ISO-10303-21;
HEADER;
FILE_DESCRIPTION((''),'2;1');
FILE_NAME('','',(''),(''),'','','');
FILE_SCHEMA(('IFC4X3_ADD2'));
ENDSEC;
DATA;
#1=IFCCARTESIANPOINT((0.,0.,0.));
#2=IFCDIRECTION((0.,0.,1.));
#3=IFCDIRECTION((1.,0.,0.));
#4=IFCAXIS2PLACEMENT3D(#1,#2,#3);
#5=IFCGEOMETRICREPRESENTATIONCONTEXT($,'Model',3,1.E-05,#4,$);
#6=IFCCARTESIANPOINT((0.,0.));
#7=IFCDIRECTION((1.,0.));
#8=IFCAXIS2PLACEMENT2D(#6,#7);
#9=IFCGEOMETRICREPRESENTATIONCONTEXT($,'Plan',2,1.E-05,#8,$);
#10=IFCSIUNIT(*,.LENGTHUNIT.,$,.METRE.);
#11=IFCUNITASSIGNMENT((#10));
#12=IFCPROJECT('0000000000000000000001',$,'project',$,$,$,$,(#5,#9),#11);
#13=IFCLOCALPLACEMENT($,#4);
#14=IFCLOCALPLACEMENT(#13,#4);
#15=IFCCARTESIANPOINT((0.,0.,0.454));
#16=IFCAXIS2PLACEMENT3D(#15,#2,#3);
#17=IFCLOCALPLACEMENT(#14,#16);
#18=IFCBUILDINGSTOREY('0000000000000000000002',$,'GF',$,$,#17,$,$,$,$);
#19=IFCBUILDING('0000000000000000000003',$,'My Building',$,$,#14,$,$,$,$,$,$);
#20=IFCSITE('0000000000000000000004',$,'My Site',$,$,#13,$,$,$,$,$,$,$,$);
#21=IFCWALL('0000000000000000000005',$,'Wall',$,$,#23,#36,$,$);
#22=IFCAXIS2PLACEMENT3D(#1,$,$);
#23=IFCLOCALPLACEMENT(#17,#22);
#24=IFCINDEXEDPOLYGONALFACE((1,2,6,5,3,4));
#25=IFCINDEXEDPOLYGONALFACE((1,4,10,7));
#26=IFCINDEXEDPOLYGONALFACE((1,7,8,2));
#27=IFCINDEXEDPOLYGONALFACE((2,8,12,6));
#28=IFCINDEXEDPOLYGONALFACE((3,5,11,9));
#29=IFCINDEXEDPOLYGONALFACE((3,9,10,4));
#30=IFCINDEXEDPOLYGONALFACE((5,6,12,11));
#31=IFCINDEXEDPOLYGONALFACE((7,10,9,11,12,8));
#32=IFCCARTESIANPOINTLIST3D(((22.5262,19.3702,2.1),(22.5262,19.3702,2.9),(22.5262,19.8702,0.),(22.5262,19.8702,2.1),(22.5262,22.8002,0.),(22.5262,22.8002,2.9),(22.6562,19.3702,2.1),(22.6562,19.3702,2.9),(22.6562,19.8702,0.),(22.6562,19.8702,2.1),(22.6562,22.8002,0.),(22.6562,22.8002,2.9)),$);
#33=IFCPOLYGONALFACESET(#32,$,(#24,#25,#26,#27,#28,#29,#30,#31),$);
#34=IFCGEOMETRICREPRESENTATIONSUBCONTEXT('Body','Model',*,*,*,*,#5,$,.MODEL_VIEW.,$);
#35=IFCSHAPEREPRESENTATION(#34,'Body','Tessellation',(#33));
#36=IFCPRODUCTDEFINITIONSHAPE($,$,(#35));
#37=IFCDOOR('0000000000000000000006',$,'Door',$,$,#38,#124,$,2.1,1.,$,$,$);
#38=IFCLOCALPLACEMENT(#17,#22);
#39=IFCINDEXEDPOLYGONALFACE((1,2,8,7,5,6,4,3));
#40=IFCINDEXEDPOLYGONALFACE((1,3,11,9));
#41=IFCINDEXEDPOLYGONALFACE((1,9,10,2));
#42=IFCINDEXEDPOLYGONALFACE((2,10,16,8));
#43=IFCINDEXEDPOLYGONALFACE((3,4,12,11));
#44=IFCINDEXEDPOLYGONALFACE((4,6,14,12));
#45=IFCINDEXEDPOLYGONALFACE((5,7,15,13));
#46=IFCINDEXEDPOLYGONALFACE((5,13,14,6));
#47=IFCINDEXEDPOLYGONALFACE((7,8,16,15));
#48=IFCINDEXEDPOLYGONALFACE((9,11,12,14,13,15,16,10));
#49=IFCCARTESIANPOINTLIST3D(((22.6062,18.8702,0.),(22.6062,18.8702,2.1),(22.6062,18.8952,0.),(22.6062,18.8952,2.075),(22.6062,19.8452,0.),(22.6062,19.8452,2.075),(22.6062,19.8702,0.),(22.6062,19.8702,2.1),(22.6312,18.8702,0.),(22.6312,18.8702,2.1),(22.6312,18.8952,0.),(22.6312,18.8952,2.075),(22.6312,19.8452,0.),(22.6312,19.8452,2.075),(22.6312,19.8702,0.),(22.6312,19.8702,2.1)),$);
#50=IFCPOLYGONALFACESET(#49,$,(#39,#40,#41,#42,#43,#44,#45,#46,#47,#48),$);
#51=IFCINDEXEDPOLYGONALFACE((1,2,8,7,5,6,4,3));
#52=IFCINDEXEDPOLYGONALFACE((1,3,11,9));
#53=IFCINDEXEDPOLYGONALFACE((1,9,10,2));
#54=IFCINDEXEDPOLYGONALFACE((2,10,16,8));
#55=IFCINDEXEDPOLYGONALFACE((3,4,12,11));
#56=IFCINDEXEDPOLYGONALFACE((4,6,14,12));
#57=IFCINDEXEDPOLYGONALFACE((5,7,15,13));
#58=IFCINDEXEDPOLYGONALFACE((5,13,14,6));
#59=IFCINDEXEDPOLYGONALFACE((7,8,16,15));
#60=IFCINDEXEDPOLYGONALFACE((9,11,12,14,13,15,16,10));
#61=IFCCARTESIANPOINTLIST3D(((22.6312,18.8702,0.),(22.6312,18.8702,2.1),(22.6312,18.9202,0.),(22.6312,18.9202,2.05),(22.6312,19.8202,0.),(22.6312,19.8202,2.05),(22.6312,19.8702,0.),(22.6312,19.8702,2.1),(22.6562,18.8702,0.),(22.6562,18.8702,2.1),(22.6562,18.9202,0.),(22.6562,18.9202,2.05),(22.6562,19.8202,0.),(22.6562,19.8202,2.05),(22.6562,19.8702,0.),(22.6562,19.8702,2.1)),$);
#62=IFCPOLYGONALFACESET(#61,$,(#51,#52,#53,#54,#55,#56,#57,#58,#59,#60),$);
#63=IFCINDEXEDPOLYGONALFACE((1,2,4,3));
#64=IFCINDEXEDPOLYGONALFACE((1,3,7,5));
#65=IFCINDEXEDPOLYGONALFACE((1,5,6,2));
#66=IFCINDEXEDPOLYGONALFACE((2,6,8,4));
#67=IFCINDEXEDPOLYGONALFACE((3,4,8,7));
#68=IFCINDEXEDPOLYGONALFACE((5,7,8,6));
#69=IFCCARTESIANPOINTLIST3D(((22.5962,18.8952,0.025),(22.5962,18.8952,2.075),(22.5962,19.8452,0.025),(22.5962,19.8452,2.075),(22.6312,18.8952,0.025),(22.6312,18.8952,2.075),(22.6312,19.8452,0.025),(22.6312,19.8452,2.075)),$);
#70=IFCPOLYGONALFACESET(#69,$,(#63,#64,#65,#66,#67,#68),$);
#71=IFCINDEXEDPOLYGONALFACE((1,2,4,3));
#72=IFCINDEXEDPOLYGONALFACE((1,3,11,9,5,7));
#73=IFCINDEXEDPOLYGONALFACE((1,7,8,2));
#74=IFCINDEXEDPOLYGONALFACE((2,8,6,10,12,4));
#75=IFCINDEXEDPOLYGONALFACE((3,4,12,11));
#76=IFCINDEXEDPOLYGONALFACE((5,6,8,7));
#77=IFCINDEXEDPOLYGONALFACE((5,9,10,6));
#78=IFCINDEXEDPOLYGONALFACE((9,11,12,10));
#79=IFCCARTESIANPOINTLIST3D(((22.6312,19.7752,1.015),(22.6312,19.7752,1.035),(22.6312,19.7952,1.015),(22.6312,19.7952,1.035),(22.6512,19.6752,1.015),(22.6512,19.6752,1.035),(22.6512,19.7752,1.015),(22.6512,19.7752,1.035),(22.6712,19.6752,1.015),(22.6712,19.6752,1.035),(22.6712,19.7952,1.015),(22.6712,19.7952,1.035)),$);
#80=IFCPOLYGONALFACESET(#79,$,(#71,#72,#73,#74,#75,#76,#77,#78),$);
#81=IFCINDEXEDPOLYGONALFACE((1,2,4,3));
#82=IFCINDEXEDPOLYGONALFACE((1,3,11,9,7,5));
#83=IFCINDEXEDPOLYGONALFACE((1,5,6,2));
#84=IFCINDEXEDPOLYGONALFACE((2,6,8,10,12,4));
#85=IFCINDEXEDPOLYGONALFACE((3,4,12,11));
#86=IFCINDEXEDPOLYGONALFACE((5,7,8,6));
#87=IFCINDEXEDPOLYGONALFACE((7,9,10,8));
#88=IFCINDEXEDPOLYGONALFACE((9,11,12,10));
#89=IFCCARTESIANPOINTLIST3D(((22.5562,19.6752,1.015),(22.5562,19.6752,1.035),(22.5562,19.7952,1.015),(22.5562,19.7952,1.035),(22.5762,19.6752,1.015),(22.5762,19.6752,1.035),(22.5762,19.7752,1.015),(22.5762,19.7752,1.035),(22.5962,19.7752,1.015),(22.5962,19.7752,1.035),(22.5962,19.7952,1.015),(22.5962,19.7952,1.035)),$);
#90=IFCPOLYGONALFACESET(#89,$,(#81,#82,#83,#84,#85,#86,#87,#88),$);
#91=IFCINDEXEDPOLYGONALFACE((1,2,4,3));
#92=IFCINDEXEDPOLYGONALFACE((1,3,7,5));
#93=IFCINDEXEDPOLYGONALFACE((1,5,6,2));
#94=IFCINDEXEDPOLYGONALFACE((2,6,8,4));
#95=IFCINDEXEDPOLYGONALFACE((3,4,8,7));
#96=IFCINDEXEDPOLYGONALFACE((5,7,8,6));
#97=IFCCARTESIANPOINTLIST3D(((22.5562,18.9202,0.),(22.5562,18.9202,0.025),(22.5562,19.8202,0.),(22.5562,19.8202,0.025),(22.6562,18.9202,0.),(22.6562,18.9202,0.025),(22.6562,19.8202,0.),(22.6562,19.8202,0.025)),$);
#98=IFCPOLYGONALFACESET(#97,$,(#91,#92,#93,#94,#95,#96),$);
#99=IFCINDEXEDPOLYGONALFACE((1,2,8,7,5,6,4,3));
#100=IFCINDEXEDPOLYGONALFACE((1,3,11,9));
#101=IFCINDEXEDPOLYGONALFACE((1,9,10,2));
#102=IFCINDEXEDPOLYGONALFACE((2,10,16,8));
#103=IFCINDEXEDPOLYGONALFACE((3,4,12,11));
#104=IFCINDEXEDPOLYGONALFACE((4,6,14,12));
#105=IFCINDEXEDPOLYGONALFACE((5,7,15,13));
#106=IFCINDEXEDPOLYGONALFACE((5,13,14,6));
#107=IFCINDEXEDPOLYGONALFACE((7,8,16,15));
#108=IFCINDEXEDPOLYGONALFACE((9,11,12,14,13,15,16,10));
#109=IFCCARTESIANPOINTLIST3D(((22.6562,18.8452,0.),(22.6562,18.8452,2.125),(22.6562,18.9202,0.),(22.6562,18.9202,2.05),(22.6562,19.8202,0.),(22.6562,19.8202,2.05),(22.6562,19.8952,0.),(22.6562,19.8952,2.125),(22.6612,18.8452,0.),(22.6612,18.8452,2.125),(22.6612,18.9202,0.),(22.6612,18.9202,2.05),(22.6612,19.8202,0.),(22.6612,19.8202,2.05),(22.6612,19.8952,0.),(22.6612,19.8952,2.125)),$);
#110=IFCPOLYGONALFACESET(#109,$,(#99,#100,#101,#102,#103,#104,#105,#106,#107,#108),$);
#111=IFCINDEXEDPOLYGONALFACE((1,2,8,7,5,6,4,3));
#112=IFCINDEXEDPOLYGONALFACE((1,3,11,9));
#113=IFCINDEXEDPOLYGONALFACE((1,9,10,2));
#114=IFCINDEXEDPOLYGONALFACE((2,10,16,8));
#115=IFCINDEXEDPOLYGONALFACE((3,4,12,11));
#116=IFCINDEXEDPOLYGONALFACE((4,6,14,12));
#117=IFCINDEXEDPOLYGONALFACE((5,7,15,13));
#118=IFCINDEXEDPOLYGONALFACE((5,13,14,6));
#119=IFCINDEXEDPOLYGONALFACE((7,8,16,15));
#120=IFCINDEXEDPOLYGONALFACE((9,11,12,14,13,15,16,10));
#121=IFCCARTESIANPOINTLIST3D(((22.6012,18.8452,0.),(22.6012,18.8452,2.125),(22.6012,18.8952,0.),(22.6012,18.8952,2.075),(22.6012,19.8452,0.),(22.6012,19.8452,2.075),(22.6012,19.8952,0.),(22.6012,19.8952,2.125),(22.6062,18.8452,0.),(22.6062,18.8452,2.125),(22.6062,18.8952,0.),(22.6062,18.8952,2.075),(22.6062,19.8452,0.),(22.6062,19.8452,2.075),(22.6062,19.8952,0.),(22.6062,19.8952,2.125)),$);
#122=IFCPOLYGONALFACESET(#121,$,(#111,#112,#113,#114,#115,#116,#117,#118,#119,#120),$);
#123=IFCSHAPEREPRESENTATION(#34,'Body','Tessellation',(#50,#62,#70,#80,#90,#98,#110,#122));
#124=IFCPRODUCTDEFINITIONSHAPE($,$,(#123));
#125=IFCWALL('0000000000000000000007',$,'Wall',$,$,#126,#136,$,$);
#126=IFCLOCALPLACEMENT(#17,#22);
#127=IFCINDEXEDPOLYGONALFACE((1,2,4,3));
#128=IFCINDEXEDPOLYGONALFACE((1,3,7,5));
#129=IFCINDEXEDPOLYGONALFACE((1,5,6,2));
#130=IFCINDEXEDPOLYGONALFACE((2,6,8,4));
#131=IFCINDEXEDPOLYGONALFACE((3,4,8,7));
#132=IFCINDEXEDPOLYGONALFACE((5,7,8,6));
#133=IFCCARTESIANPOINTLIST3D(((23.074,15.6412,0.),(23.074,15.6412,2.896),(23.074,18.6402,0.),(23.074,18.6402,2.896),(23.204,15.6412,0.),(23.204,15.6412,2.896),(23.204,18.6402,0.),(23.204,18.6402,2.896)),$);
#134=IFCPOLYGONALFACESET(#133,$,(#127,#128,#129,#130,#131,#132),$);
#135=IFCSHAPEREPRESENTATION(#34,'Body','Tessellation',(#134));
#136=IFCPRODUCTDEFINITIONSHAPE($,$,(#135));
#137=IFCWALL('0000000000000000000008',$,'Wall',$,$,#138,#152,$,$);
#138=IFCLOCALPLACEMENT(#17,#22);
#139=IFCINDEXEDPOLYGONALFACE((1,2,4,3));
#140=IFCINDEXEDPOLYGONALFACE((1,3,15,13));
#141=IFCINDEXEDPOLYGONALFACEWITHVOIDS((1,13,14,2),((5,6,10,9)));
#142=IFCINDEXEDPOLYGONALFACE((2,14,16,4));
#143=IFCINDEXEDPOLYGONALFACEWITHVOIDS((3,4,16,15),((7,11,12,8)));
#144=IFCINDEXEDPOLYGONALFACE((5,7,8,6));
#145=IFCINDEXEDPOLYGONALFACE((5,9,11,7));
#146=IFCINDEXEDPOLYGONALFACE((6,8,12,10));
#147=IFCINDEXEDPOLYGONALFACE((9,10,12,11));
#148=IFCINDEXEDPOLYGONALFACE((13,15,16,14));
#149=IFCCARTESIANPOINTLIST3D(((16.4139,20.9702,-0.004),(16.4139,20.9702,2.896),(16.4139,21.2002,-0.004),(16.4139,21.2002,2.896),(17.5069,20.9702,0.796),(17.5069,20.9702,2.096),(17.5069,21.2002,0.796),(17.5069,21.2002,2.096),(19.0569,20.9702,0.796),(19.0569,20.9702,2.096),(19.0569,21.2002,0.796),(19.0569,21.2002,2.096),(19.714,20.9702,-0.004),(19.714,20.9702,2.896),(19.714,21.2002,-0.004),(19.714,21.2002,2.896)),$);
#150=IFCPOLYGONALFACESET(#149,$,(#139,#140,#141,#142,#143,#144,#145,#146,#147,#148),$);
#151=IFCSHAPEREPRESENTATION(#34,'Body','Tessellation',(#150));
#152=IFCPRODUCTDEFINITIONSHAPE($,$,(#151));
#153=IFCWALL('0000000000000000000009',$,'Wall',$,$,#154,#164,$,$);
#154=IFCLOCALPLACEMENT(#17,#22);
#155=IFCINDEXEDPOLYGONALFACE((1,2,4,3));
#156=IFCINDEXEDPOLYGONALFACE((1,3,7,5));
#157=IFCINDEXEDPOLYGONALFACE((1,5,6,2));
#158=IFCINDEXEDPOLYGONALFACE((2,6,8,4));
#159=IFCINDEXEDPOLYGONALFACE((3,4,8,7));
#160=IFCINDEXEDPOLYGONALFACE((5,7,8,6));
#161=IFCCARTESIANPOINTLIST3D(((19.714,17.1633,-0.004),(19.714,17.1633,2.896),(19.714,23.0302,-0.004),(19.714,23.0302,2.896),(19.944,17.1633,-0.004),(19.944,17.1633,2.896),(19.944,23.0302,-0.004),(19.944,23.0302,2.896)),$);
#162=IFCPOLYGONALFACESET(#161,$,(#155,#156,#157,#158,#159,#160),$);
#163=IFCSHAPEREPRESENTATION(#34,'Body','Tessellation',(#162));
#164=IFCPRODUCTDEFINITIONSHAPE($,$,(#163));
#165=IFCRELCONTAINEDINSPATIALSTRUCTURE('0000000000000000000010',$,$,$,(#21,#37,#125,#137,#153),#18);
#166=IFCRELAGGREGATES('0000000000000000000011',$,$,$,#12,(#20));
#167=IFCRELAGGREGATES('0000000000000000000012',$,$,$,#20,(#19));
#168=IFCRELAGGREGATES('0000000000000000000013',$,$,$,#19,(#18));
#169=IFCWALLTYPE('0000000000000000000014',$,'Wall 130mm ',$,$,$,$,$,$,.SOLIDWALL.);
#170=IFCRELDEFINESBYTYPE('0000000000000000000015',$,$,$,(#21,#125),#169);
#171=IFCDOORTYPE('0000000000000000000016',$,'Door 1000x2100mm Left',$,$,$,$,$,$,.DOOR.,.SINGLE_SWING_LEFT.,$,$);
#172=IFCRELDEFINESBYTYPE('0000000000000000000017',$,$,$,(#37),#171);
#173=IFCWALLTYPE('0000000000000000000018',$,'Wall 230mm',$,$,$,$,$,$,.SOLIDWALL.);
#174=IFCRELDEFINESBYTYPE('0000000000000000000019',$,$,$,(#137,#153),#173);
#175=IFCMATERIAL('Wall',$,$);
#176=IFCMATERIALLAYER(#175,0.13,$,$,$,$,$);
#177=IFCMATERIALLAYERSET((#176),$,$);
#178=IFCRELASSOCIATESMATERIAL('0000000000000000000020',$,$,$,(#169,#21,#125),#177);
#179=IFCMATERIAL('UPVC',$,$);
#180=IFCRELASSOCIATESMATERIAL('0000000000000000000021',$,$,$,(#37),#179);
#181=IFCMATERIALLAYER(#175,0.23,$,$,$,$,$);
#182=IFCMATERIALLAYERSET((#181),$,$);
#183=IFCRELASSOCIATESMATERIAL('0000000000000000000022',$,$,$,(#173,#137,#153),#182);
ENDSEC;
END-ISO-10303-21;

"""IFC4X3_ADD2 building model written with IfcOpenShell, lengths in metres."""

from ifc_helpers import new_model, entity, si_unit, frame, origin_with_axes, origin_2d_with_axis, place, context, subcontext, project, spatial, line, indexed_curve, outline, extrude, clip, halfspace, shape, source, transform, mapped, material, layer, layer_set, layer_usage, type_object, type_shapes, element, fill, save


model = new_model("IFC4X3_ADD2")

# Units and contexts
model_context = context("Model", 3, precision=1e-05, world=origin_with_axes())
plan_context = context("Plan", 2, precision=1e-05, world=origin_2d_with_axis())
body_context_1 = subcontext(model_context, "Body", "Model", "MODEL_VIEW")
body_context_2 = subcontext(plan_context, "Body", "Plan", "PLAN_VIEW")
ifc_project = project(units=[si_unit("LENGTHUNIT", "METRE")], contexts=[model_context, plan_context])

# Site, building, storey
site_placement = place(None, origin_with_axes())
site = spatial("IfcSite", under=ifc_project, at=site_placement, Name="My Site")
building_placement = place(site_placement, origin_with_axes())
building = spatial("IfcBuilding", under=site, at=building_placement, Name="My Building")
storey_placement = place(building_placement, frame((0.0, 0.0, 0.454), z_axis=(0.0, 0.0, 1.0), x_axis=(1.0, 0.0, 0.0)))
storey = spatial("IfcBuildingStorey", under=building, at=storey_placement, Name="GF")

# Shared definitions
ifc_material_1 = material(Name="Wall")
ifc_layer_1 = layer(ifc_material_1, 0.13)
ifc_layer_set_1 = layer_set([ifc_layer_1])
wall_type_1 = type_object("IfcWallType", Name="Wall 130mm ", PredefinedType="SOLIDWALL", material=ifc_layer_set_1)
ifc_material_2 = material(Name="UPVC")

# Wall, opening, door
ifc_layer_usage_1 = layer_usage(ifc_layer_set_1, "AXIS2", "POSITIVE", 0.0)
wall_1_placement = place(storey_placement, frame((22.6562, 19.3702, 0.0), z_axis=(0.0, 0.0, 1.0), x_axis=(0.000002, 1.0, 0.0)))
wall_1 = element("IfcWall", 1, at=wall_1_placement, inside=storey, type_object=wall_type_1, material=ifc_layer_usage_1, Name="Wall", context=body_context_1, shape_type="SweptSolid", body=[
    extrude(outline(indexed_curve([(0.0, 0.0), (0.0, 0.13), (3.43, 0.13), (3.43, 0.0), (0.0, 0.0)], self_intersect=False)), origin_with_axes(), (0.0, 0.0, 1.0), 2.9),
])
shared_shape_1 = source(origin_with_axes(), body_context_1, "Body", "SweptSolid", [
    extrude(outline(indexed_curve([(0.0, 0.0), (1.0, 0.0), (1.0, 2.1), (0.0, 2.1)], segments=[line(1, 2, 3, 4, 1)])), frame((0.0, -0.6, 0.0), z_axis=(0.0, -1.0, 0.0), x_axis=(1.0, 0.0, 0.0)), (0.0, 0.0, -1.0), 1.2),
])
opening_1_placement = place(wall_1_placement, frame((-0.5, 0.0, 0.0), z_axis=(0.0, 0.0, 1.0), x_axis=(1.0, 0.0, 0.0)))
opening_1 = element("IfcOpeningElement", 2, at=opening_1_placement, cuts=wall_1, PredefinedType="OPENING", context=body_context_1, shape_type="MappedRepresentation", body=[
    mapped(shared_shape_1, transform((0.0, 0.0, 0.0), x_axis=(1.0, 0.0, 0.0), y_axis=(0.0, 1.0, 0.0), z_axis=(0.0, 0.0, 1.0), scale=1.0)),
])
door_type_1 = type_object("IfcDoorType", Name="Door 1000x2100mm Left", OperationType="SINGLE_SWING_LEFT", PredefinedType="DOOR")
shared_shape_2 = source(origin_with_axes(), body_context_1, "Body", "SweptSolid", [
    extrude(outline(indexed_curve([(0.0, 0.0), (0.0, 2.1), (1.0, 2.1), (1.0, 0.0), (0.975, 0.0), (0.975, 2.075), (0.025, 2.075), (0.025, 0.0)], segments=[line(1, 2, 3, 4, 5, 6, 7, 8, 1)])), frame((0.0, 0.025, 0.0), z_axis=(0.0, -1.0, 0.0), x_axis=(1.0, 0.0, 0.0)), (0.0, 0.0, -1.0), 0.025),
    extrude(outline(indexed_curve([(0.0, 0.0), (0.0, 2.1), (1.0, 2.1), (1.0, 0.0), (0.95, 0.0), (0.95, 2.05), (0.05, 2.05), (0.05, 0.0)], segments=[line(1, 2, 3, 4, 5, 6, 7, 8, 1)])), frame((0.0, 0.0, 0.0), z_axis=(0.0, -1.0, 0.0), x_axis=(1.0, 0.0, 0.0)), (0.0, 0.0, -1.0), 0.025),
    extrude(outline(indexed_curve([(0.0, 0.0), (0.95, 0.0), (0.95, 0.035), (0.0, 0.035)], segments=[line(1, 2, 3, 4, 1)])), frame((0.025, 0.025, 0.025), z_axis=(0.0, 0.0, 1.0), x_axis=(1.0, 0.0, 0.0)), (0.0, 0.0, 1.0), 2.05),
    extrude(outline(indexed_curve([(0.0, 0.0), (0.0, -0.04), (-0.12, -0.04), (-0.12, -0.02), (-0.02, -0.02), (-0.02, 0.0)], segments=[line(1, 2, 3, 4, 5, 6, 1)])), frame((0.925, 0.025, 1.015), z_axis=(0.0, 0.0, 1.0), x_axis=(1.0, 0.0, 0.0)), (0.0, 0.0, 1.0), 0.02),
    extrude(outline(indexed_curve([(0.0, 0.0), (0.0, 0.04), (-0.12, 0.04), (-0.12, 0.02), (-0.02, 0.02), (-0.02, 0.0)], segments=[line(1, 2, 3, 4, 5, 6, 1)])), frame((0.925, 0.06, 1.015), z_axis=(0.0, 0.0, 1.0), x_axis=(1.0, 0.0, 0.0)), (0.0, 0.0, 1.0), 0.02),
    extrude(outline(indexed_curve([(0.0, 0.0), (0.9, 0.0), (0.9, 0.1), (0.0, 0.1)], segments=[line(1, 2, 3, 4, 1)])), frame((0.05, 0.0, 0.0), z_axis=(0.0, 0.0, 1.0), x_axis=(1.0, 0.0, 0.0)), (0.0, 0.0, 1.0), 0.025),
    extrude(outline(indexed_curve([(0.0, 0.0), (0.0, 2.125), (1.05, 2.125), (1.05, 0.0), (0.975, 0.0), (0.975, 2.05), (0.075, 2.05), (0.075, 0.0)], segments=[line(1, 2, 3, 4, 5, 6, 7, 8, 1)])), frame((-0.025, -0.005, 0.0), z_axis=(0.0, -1.0, 0.0), x_axis=(1.0, 0.0, 0.0)), (0.0, 0.0, -1.0), 0.005),
    extrude(outline(indexed_curve([(0.0, 0.0), (0.0, 2.125), (1.05, 2.125), (1.05, 0.0), (1.0, 0.0), (1.0, 2.075), (0.05, 2.075), (0.05, 0.0)], segments=[line(1, 2, 3, 4, 5, 6, 7, 8, 1)])), frame((-0.025, 0.05, 0.0), z_axis=(0.0, -1.0, 0.0), x_axis=(1.0, 0.0, 0.0)), (0.0, 0.0, -1.0), 0.005),
])
shared_shape_3 = source(origin_with_axes(), body_context_2, "Body", "Curve2D", [
    entity("IfcIndexedPolyCurve", entity("IfcCartesianPointList2D", [[0.0, 0.0], [0.0, 0.05], [0.025, 0.05], [0.025, 0.025], [0.05, 0.025], [0.05, 0.0]]), [entity("IfcLineIndex", [1, 2, 3, 4, 5, 6, 1])]),
    entity("IfcIndexedPolyCurve", entity("IfcCartesianPointList2D", [[1.0, 0.0], [1.0, 0.05], [0.975, 0.05], [0.975, 0.025], [0.95, 0.025], [0.95, 0.0]]), [entity("IfcLineIndex", [1, 2, 3, 4, 5, 6, 1])]),
    entity("IfcTrimmedCurve", entity("IfcEllipse", entity("IfcAxis2Placement2D", entity("IfcCartesianPoint", [0.06, 0.05]), entity("IfcDirection", [1.0, 0.0])), 0.915, 0.95), [entity("IfcCartesianPoint", [0.975, 0.05])], [entity("IfcCartesianPoint", [0.06, 1.0])], True, "CARTESIAN"),
    entity("IfcIndexedPolyCurve", entity("IfcCartesianPointList2D", [[0.025, 0.05], [0.06, 0.05], [0.06, 1.0], [0.025, 1.0]]), [entity("IfcLineIndex", [1, 2, 3, 4, 1])]),
])
type_shapes(door_type_1, [shared_shape_2, shared_shape_3])
door_1_placement = place(opening_1_placement, frame((0.0, 0.0, 0.0), z_axis=(0.0, 0.0, 1.0), x_axis=(1.0, 0.0, 0.0)))
door_1 = element("IfcDoor", 3, at=door_1_placement, inside=storey, type_object=door_type_1, material=ifc_material_2, Name="Door", OverallHeight=2.1, OverallWidth=1.0, shapes=[
    shape(body_context_1, "Body", "MappedRepresentation", [mapped(shared_shape_2, transform((0.0, 0.0, 0.0), x_axis=(1.0, 0.0, 0.0), y_axis=(0.0, 1.0, 0.0), z_axis=(0.0, 0.0, 1.0), scale=1.0))]),
    shape(body_context_2, "Body", "MappedRepresentation", [mapped(shared_shape_3, transform((0.0, 0.0, 0.0), x_axis=(1.0, 0.0, 0.0), y_axis=(0.0, 1.0, 0.0), z_axis=(0.0, 0.0, 1.0), scale=1.0))]),
])
fill(opening_1, door_1)

# Wall
ifc_layer_usage_2 = layer_usage(ifc_layer_set_1, "AXIS2", "POSITIVE", 0.0)
wall_2_placement = place(storey_placement, frame((23.204, 15.6412, 0.0), z_axis=(0.0, 0.0, 1.0), x_axis=(0.000001, 1.0, 0.0)))
element("IfcWall", 4, at=wall_2_placement, inside=storey, type_object=wall_type_1, material=ifc_layer_usage_2, Name="Wall", context=body_context_1, shape_type="Clipping", body=[
    clip(extrude(outline(indexed_curve([(0.0, 0.0), (0.0, 0.13), (2.999, 0.13), (2.999, 0.0), (0.0, 0.0)], self_intersect=False)), origin_with_axes(), (0.0, 0.0, 1.0), 3.35), halfspace(frame((0.0, 0.0, 2.896), z_axis=(0.0, 0.0, 1.0), x_axis=(-1.0, 0.0, 0.0)), False)),
])

# Wall, opening
ifc_layer_2 = layer(ifc_material_1, 0.23)
ifc_layer_set_2 = layer_set([ifc_layer_2])
ifc_layer_usage_3 = layer_usage(ifc_layer_set_2, "AXIS2", "POSITIVE", 0.0)
wall_type_2 = type_object("IfcWallType", Name="Wall 230mm", PredefinedType="SOLIDWALL", material=ifc_layer_set_2)
wall_3_placement = place(storey_placement, frame((19.714, 21.2002, -0.004), z_axis=(0.0, 0.0, 1.0), x_axis=(-1.0, 0.0, 0.0)))
wall_3 = element("IfcWall", 5, at=wall_3_placement, inside=storey, type_object=wall_type_2, material=ifc_layer_usage_3, Name="Wall", context=body_context_1, shape_type="SweptSolid", body=[
    extrude(outline(indexed_curve([(0.0, 0.0), (0.0, 0.23), (3.3, 0.23), (3.3, 0.0), (0.0, 0.0)], self_intersect=False)), origin_with_axes(), (0.0, 0.0, 1.0), 2.9),
])
shared_shape_4 = source(origin_with_axes(), body_context_1, "Body", "SweptSolid", [
    extrude(outline(indexed_curve([(0.0, 0.0), (1.55, 0.0), (1.55, 1.3), (0.0, 1.3)], segments=[line(1, 2, 3, 4, 1)])), frame((-0.775, -0.6, 0.0), z_axis=(0.0, -1.0, 0.0), x_axis=(1.0, 0.0, 0.0)), (0.0, 0.0, -1.0), 1.2),
])
opening_2_placement = place(wall_3_placement, frame((1.432, 0.0, 0.8), z_axis=(0.0, 0.0, 1.0), x_axis=(1.0, 0.0, 0.0)))
element("IfcOpeningElement", 6, at=opening_2_placement, cuts=wall_3, PredefinedType="OPENING", context=body_context_1, shape_type="MappedRepresentation", body=[
    mapped(shared_shape_4, transform((0.0, 0.0, 0.0), x_axis=(1.0, 0.0, 0.0), y_axis=(0.0, 1.0, 0.0), z_axis=(0.0, 0.0, 1.0), scale=1.0)),
])

# Wall
ifc_layer_usage_4 = layer_usage(ifc_layer_set_2, "AXIS2", "POSITIVE", 0.0)
wall_4_placement = place(storey_placement, frame((19.944, 17.1633, -0.004), z_axis=(0.0, 0.0, 1.0), x_axis=(0.000001, 1.0, 0.0)))
element("IfcWall", 7, at=wall_4_placement, inside=storey, type_object=wall_type_2, material=ifc_layer_usage_4, Name="Wall", context=body_context_1, shape_type="SweptSolid", body=[
    extrude(outline(indexed_curve([(0.0, 0.0), (0.0, 0.23), (5.8669, 0.23), (5.8669, 0.0), (0.0, 0.0)], self_intersect=False)), origin_with_axes(), (0.0, 0.0, 1.0), 2.9),
])

save(model, "model.ifc")
